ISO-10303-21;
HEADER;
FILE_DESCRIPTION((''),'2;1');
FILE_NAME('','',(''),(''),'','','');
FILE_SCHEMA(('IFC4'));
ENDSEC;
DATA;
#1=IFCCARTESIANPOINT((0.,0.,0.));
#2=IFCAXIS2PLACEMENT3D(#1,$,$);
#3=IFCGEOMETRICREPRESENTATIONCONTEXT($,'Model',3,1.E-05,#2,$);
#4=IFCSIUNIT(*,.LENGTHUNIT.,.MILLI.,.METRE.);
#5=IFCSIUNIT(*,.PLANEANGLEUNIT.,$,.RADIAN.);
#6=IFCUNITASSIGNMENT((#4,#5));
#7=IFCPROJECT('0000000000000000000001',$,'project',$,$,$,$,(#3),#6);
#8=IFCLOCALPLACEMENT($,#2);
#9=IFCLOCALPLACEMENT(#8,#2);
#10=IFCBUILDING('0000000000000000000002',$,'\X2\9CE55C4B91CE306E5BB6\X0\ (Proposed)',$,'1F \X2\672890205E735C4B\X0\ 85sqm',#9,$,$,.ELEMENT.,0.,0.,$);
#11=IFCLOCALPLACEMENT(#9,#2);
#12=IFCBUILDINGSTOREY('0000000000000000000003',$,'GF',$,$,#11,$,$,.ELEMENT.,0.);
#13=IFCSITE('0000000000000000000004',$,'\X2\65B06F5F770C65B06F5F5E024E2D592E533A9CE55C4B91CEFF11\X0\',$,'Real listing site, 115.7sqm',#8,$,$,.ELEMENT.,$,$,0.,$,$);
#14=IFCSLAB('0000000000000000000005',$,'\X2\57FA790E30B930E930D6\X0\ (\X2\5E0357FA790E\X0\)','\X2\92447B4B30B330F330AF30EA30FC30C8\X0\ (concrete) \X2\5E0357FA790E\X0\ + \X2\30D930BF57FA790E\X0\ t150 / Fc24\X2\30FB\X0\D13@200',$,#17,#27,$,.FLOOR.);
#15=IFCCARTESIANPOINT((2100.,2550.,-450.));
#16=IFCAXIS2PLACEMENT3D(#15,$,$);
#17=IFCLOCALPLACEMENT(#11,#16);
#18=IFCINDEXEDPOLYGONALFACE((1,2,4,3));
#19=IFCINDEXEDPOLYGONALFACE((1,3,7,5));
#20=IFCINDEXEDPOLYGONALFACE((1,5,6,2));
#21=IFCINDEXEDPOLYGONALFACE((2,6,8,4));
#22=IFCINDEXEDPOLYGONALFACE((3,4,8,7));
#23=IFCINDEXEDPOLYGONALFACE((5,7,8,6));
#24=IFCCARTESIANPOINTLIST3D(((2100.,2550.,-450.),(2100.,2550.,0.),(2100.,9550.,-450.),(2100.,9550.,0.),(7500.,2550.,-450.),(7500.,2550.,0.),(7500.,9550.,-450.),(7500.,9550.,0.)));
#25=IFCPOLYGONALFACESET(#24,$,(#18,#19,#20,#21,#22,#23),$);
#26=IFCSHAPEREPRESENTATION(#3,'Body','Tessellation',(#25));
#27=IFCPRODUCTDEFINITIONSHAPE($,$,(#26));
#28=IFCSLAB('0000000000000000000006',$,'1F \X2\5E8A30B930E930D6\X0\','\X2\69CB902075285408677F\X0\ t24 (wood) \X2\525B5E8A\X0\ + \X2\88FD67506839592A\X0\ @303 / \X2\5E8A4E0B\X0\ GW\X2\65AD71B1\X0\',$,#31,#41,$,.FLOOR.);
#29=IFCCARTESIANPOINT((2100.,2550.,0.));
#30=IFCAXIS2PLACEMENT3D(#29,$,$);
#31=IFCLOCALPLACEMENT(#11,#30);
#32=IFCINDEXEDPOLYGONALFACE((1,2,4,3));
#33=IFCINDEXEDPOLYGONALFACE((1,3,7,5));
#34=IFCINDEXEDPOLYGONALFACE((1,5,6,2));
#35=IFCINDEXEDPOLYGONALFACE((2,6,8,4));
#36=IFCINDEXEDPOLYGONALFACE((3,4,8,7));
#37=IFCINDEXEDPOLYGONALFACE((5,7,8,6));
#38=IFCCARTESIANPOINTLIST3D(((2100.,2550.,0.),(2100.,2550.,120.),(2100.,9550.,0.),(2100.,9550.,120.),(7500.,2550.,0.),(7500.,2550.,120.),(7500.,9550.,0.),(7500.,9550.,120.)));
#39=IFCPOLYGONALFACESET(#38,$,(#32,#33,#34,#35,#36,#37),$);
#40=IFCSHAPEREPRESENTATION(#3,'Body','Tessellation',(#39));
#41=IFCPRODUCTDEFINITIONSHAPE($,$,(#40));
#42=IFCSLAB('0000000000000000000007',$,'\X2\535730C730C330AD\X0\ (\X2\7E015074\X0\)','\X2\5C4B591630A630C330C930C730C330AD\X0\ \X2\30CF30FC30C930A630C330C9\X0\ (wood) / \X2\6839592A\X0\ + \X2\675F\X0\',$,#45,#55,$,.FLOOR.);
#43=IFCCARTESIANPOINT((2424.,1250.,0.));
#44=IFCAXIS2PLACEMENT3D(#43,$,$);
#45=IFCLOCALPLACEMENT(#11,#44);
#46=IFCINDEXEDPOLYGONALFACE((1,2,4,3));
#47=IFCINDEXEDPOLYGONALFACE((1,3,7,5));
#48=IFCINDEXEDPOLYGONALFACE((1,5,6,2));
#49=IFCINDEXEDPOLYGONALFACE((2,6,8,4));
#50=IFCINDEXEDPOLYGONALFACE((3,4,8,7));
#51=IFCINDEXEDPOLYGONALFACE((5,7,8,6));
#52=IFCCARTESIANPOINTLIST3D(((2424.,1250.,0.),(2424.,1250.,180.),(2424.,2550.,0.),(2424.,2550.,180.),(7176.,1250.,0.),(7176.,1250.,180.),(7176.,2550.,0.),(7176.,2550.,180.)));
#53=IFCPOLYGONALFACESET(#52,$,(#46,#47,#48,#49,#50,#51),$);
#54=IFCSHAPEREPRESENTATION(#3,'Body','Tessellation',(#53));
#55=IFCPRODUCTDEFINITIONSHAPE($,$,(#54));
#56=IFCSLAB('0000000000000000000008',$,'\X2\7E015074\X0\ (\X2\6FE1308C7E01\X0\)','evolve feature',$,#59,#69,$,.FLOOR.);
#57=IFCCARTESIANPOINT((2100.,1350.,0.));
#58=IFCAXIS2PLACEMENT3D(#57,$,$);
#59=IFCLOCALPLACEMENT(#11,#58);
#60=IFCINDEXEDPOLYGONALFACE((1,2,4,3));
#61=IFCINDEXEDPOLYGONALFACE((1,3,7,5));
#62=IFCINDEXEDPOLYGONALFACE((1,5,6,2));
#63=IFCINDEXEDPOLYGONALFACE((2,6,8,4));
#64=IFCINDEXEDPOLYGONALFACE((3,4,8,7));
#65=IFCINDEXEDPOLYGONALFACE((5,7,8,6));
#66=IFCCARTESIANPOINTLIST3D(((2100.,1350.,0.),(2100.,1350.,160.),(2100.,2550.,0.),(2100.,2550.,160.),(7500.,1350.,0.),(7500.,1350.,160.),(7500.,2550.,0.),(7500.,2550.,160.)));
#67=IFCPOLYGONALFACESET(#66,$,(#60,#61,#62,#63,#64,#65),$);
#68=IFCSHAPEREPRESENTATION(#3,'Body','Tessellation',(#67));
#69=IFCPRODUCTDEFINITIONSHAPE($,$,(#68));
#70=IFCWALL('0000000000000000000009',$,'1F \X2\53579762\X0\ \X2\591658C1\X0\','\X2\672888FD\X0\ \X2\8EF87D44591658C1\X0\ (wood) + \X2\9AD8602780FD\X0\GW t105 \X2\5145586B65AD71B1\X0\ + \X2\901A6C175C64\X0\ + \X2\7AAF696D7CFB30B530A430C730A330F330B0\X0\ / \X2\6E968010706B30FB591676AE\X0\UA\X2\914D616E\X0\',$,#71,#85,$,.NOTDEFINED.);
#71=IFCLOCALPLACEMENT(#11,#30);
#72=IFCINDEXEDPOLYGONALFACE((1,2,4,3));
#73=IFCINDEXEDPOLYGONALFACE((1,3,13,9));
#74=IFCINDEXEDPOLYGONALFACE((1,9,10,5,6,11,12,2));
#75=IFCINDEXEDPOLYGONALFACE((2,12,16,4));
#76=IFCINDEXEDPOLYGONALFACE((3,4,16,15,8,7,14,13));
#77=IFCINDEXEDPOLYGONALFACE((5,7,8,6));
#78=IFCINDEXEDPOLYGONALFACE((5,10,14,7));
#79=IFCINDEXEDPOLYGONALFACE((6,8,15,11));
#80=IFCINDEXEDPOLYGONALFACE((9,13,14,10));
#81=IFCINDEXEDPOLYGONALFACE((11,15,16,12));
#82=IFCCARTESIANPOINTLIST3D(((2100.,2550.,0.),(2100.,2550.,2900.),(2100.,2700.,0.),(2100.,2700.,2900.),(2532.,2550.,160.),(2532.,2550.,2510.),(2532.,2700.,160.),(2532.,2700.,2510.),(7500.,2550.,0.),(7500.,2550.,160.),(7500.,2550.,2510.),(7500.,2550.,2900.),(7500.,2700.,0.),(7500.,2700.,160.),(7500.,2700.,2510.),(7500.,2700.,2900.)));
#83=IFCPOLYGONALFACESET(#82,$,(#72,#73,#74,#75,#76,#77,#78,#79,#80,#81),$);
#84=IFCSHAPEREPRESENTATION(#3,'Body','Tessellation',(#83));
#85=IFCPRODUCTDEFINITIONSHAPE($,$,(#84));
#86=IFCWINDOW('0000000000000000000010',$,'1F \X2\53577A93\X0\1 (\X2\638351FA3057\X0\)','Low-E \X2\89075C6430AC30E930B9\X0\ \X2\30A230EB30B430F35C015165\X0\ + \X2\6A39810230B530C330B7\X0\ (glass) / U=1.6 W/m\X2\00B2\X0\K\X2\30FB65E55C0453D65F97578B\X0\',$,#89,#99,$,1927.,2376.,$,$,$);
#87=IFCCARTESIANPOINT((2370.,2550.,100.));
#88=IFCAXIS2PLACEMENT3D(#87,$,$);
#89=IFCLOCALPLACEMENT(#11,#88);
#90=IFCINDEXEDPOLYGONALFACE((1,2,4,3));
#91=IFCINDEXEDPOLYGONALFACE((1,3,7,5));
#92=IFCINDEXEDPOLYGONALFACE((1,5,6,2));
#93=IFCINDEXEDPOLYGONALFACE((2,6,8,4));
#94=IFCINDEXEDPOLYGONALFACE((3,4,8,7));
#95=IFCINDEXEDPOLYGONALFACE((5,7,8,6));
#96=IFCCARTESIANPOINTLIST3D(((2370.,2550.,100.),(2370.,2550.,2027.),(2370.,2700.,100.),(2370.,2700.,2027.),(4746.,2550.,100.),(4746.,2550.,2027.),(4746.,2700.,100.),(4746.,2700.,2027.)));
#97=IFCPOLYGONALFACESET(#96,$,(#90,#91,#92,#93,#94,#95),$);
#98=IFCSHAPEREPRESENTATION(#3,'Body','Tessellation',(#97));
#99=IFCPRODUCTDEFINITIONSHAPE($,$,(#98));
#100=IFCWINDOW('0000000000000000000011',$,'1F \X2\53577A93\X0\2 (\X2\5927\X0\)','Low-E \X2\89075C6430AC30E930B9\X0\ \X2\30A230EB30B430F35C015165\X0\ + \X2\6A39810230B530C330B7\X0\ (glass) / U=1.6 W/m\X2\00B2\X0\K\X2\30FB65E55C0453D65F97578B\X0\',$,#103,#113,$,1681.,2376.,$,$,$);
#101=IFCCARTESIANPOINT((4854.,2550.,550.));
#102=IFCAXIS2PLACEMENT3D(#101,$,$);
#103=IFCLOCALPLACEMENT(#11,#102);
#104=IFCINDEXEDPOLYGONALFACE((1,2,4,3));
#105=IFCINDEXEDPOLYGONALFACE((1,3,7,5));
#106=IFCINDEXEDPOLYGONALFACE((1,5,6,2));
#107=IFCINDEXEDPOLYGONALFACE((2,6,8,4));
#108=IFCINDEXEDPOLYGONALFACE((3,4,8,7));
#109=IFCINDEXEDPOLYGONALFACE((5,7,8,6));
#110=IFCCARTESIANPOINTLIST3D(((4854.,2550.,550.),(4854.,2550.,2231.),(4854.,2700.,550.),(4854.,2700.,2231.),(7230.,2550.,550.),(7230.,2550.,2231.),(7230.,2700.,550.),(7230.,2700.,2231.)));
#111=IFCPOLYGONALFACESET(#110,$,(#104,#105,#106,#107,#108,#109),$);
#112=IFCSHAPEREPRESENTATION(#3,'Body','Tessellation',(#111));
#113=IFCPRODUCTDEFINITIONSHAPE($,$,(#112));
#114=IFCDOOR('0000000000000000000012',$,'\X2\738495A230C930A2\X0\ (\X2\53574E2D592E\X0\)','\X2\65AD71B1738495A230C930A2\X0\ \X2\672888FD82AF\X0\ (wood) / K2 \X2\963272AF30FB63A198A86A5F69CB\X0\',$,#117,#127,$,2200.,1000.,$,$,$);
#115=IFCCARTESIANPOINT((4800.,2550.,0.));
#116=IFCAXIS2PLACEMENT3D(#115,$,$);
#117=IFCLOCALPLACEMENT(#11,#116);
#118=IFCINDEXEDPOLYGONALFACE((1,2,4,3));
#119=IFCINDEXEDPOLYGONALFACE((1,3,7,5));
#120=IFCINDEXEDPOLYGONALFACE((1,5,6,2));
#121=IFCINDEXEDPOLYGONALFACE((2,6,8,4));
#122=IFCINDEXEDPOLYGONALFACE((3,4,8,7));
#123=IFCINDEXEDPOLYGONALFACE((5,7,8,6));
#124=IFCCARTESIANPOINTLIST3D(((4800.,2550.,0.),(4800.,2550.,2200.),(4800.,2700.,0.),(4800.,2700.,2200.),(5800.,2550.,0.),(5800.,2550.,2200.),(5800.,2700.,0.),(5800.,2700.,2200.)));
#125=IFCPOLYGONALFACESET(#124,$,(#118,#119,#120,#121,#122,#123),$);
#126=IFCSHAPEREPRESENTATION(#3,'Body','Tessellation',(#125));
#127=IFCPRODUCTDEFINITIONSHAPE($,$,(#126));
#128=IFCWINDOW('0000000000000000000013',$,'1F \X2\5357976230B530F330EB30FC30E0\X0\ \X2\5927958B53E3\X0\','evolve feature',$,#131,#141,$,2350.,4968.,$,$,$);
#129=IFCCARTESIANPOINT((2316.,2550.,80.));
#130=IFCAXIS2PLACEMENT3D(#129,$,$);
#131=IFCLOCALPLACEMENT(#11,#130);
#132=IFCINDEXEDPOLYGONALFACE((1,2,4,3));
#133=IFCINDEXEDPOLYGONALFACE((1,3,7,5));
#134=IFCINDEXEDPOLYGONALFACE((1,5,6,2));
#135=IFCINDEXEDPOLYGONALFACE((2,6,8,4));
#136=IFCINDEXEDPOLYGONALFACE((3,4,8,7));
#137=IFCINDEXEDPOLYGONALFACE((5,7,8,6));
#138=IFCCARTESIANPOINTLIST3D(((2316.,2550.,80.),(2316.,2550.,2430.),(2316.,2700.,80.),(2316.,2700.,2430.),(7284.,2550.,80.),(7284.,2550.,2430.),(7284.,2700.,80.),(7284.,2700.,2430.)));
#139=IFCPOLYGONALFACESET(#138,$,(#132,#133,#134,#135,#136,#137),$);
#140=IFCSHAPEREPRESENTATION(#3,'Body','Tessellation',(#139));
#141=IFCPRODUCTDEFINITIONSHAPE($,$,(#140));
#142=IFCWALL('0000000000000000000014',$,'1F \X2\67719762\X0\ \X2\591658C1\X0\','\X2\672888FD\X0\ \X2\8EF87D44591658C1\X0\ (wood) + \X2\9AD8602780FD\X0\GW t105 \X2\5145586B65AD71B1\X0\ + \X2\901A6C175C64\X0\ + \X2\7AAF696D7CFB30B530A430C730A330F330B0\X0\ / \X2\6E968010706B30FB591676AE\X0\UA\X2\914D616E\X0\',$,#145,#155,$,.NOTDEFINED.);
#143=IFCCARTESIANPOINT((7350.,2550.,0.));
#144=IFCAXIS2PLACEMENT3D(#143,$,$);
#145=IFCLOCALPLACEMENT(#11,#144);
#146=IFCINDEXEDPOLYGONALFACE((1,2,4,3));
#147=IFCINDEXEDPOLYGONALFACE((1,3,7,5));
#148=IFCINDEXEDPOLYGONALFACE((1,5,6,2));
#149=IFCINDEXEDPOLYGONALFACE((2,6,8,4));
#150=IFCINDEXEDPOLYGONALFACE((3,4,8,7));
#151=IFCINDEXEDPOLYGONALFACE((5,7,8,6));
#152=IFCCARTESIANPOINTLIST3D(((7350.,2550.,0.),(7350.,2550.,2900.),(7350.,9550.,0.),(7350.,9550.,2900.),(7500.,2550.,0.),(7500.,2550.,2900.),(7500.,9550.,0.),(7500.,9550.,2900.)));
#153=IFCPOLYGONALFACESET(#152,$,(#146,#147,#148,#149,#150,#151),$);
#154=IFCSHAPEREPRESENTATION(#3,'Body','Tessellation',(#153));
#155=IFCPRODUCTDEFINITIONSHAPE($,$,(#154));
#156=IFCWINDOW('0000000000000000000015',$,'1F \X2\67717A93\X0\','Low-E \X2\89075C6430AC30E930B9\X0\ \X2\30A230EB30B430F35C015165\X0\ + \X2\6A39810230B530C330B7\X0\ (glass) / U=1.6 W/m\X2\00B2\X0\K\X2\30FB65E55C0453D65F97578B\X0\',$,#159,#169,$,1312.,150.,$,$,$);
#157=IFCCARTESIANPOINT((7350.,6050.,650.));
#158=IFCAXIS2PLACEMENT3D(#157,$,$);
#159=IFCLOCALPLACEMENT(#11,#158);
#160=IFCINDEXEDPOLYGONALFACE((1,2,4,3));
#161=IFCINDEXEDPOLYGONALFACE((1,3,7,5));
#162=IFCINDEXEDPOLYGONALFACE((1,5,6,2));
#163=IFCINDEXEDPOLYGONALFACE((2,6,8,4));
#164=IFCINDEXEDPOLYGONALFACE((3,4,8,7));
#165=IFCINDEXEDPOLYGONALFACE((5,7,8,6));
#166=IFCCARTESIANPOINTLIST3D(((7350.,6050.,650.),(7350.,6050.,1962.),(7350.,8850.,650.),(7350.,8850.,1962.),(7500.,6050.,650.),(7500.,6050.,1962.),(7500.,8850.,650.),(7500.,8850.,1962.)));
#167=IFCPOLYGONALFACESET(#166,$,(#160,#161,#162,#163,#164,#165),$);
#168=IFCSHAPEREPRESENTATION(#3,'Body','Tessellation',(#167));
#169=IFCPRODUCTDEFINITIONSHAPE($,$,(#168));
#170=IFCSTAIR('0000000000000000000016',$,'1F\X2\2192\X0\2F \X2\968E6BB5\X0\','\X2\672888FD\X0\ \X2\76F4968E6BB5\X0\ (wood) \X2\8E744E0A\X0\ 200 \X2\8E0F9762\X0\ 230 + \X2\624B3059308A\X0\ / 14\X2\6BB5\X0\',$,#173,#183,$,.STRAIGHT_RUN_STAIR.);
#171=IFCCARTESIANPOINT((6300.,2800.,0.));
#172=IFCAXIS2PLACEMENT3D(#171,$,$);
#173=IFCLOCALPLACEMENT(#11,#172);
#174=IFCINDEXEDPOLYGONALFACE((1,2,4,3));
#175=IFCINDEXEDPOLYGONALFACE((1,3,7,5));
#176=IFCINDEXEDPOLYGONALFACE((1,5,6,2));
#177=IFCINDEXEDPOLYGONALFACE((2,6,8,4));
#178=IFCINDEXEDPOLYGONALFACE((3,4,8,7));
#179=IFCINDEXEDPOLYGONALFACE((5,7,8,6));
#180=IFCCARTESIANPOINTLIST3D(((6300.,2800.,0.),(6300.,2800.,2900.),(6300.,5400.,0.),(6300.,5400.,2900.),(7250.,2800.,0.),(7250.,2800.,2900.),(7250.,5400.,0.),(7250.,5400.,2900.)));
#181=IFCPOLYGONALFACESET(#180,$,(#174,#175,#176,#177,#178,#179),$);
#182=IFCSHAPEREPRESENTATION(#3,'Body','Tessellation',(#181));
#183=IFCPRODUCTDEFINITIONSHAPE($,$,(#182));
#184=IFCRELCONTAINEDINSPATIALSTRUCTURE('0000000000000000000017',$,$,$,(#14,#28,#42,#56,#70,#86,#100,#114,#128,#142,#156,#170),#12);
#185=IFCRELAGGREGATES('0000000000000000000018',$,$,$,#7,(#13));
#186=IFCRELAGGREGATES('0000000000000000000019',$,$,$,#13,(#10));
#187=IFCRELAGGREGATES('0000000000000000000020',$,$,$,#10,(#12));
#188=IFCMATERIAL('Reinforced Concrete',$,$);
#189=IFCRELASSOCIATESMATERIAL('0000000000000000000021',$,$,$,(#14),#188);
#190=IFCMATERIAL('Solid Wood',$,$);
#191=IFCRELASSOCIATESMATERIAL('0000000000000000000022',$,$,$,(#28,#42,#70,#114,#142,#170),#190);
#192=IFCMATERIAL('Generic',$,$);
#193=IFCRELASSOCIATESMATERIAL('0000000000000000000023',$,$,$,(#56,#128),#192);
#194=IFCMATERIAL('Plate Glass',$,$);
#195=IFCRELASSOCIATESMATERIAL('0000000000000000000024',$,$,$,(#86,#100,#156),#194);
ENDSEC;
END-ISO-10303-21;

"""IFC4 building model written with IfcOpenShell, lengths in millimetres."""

from ifc_helpers import new_model, si_unit, frame, frame_2d, origin, place, context, project, spatial, rectangle, extrude, material, element, fill, save


model = new_model("IFC4")

# Units and contexts
model_context = context("Model", 3, precision=1e-05, world=origin())
ifc_project = project(units=[si_unit("LENGTHUNIT", "METRE", prefix="MILLI"), si_unit("PLANEANGLEUNIT", "RADIAN")], contexts=[model_context])

# Site, building, storey
site_placement = place(None, origin())
site = spatial("IfcSite", under=ifc_project, at=site_placement, Name="新潟県新潟市中央区鳥屋野１", ObjectType="Real listing site, 115.7sqm", CompositionType="ELEMENT", RefElevation=0.0)
building_placement = place(site_placement, origin())
building = spatial("IfcBuilding", under=site, at=building_placement, Name="鳥屋野の家 (Proposed)", ObjectType="1F 木造平屋 85sqm", CompositionType="ELEMENT", ElevationOfRefHeight=0.0, ElevationOfTerrain=0.0)
storey_placement = place(building_placement, origin())
storey = spatial("IfcBuildingStorey", under=building, at=storey_placement, Name="GF", CompositionType="ELEMENT", Elevation=0.0)

# Slabs
ifc_material_1 = material(Name="Reinforced Concrete")
slab_1_placement = place(storey_placement, frame((2100.0, 2550.0, -450.0)))
element("IfcSlab", 1, at=slab_1_placement, inside=storey, material=ifc_material_1, Name="基礎スラブ (布基礎)", Description="鉄筋コンクリート (concrete) 布基礎 + ベタ基礎 t150 / Fc24・D13@200", PredefinedType="FLOOR", context=model_context, shape_type="SweptSolid", body=[
    extrude(rectangle(XDim=5400.0, YDim=7000.0, at=frame_2d((2700.0, 3500.0))), frame((2100.0, 2550.0, -450.0)), (0.0, 0.0, 1.0), 450.0),
])
ifc_material_2 = material(Name="Solid Wood")
slab_2_placement = place(storey_placement, frame((2100.0, 2550.0, 0.0)))
element("IfcSlab", 2, at=slab_2_placement, inside=storey, material=ifc_material_2, Name="1F 床スラブ", Description="構造用合板 t24 (wood) 剛床 + 製材根太 @303 / 床下 GW断熱", PredefinedType="FLOOR", context=model_context, shape_type="SweptSolid", body=[
    extrude(rectangle(XDim=5400.0, YDim=7000.0, at=frame_2d((2700.0, 3500.0))), frame((2100.0, 2550.0, 0.0)), (0.0, 0.0, 1.0), 120.0),
])
slab_3_placement = place(storey_placement, frame((2424.0, 1250.0, 0.0)))
element("IfcSlab", 3, at=slab_3_placement, inside=storey, material=ifc_material_2, Name="南デッキ (縁側)", Description="屋外ウッドデッキ ハードウッド (wood) / 根太 + 束", PredefinedType="FLOOR", context=model_context, shape_type="SweptSolid", body=[
    extrude(rectangle(XDim=4752.0, YDim=1300.0, at=frame_2d((2376.0, 650.0))), frame((2424.0, 1250.0, 0.0)), (0.0, 0.0, 1.0), 180.0),
])
ifc_material_3 = material(Name="Generic")
slab_4_placement = place(storey_placement, frame((2100.0, 1350.0, 0.0)))
element("IfcSlab", 4, at=slab_4_placement, inside=storey, material=ifc_material_3, Name="縁側 (濡れ縁)", Description="evolve feature", PredefinedType="FLOOR", context=model_context, shape_type="SweptSolid", body=[
    extrude(rectangle(XDim=5400.0, YDim=1200.0, at=frame_2d((2700.0, 600.0))), frame((2100.0, 1350.0, 0.0)), (0.0, 0.0, 1.0), 160.0),
])

# Wall, openings, windows, door
wall_1_placement = place(storey_placement, frame((2100.0, 2550.0, 0.0)))
wall_1 = element("IfcWall", 5, at=wall_1_placement, inside=storey, material=ifc_material_2, Name="1F 南面 外壁", Description="木製 軸組外壁 (wood) + 高性能GW t105 充填断熱 + 通気層 + 窯業系サイディング / 準耐火・外皮UA配慮", PredefinedType="NOTDEFINED", context=model_context, shape_type="SweptSolid", body=[
    extrude(rectangle(XDim=5400.0, YDim=150.0, at=frame_2d((2700.0, 75.0))), frame((2100.0, 2550.0, 0.0)), (0.0, 0.0, 1.0), 2900.0),
])
opening_1_placement = place(storey_placement, frame((2370.0, 2550.0, 100.0)))
opening_1 = element("IfcOpeningElement", 6, at=opening_1_placement, cuts=wall_1, PredefinedType="NOTDEFINED", context=model_context, shape_type="SweptSolid", body=[
    extrude(rectangle(XDim=2376.0, YDim=150.0, at=frame_2d((1188.0, 75.0))), frame((2370.0, 2550.0, 100.0)), (0.0, 0.0, 1.0), 1927.0),
])
opening_2_placement = place(storey_placement, frame((4854.0, 2550.0, 550.0)))
opening_2 = element("IfcOpeningElement", 7, at=opening_2_placement, cuts=wall_1, PredefinedType="NOTDEFINED", context=model_context, shape_type="SweptSolid", body=[
    extrude(rectangle(XDim=2376.0, YDim=150.0, at=frame_2d((1188.0, 75.0))), frame((4854.0, 2550.0, 550.0)), (0.0, 0.0, 1.0), 1681.0),
])
opening_3_placement = place(storey_placement, frame((4800.0, 2550.0, 0.0)))
opening_3 = element("IfcOpeningElement", 8, at=opening_3_placement, cuts=wall_1, PredefinedType="NOTDEFINED", context=model_context, shape_type="SweptSolid", body=[
    extrude(rectangle(XDim=1000.0, YDim=150.0, at=frame_2d((500.0, 75.0))), frame((4800.0, 2550.0, 0.0)), (0.0, 0.0, 1.0), 2200.0),
])
opening_4_placement = place(storey_placement, frame((2316.0, 2550.0, 80.0)))
opening_4 = element("IfcOpeningElement", 9, at=opening_4_placement, cuts=wall_1, PredefinedType="NOTDEFINED", context=model_context, shape_type="SweptSolid", body=[
    extrude(rectangle(XDim=4968.0, YDim=150.0, at=frame_2d((2484.0, 75.0))), frame((2316.0, 2550.0, 80.0)), (0.0, 0.0, 1.0), 2350.0),
])
ifc_material_4 = material(Name="Plate Glass")
window_1_placement = place(storey_placement, frame((2370.0, 2550.0, 100.0)))
window_1 = element("IfcWindow", 10, at=window_1_placement, inside=storey, material=ifc_material_4, Name="1F 南窓1 (掃出し)", Description="Low-E 複層ガラス アルゴン封入 + 樹脂サッシ (glass) / U=1.6 W/m²K・日射取得型", OverallHeight=1927.0, OverallWidth=2376.0, context=model_context, shape_type="SweptSolid", body=[
    extrude(rectangle(XDim=2376.0, YDim=150.0, at=frame_2d((1188.0, 75.0))), frame((2370.0, 2550.0, 100.0)), (0.0, 0.0, 1.0), 1927.0),
])
fill(opening_1, window_1)
window_2_placement = place(storey_placement, frame((4854.0, 2550.0, 550.0)))
window_2 = element("IfcWindow", 11, at=window_2_placement, inside=storey, material=ifc_material_4, Name="1F 南窓2 (大)", Description="Low-E 複層ガラス アルゴン封入 + 樹脂サッシ (glass) / U=1.6 W/m²K・日射取得型", OverallHeight=1681.0, OverallWidth=2376.0, context=model_context, shape_type="SweptSolid", body=[
    extrude(rectangle(XDim=2376.0, YDim=150.0, at=frame_2d((1188.0, 75.0))), frame((4854.0, 2550.0, 550.0)), (0.0, 0.0, 1.0), 1681.0),
])
fill(opening_2, window_2)
door_placement = place(storey_placement, frame((4800.0, 2550.0, 0.0)))
door = element("IfcDoor", 12, at=door_placement, inside=storey, material=ifc_material_2, Name="玄関ドア (南中央)", Description="断熱玄関ドア 木製芯 (wood) / K2 防犯・採風機構", OverallHeight=2200.0, OverallWidth=1000.0, context=model_context, shape_type="SweptSolid", body=[
    extrude(rectangle(XDim=1000.0, YDim=150.0, at=frame_2d((500.0, 75.0))), frame((4800.0, 2550.0, 0.0)), (0.0, 0.0, 1.0), 2200.0),
])
fill(opening_3, door)
window_3_placement = place(storey_placement, frame((2316.0, 2550.0, 80.0)))
window_3 = element("IfcWindow", 13, at=window_3_placement, inside=storey, material=ifc_material_3, Name="1F 南面サンルーム 大開口", Description="evolve feature", OverallHeight=2350.0, OverallWidth=4968.0, context=model_context, shape_type="SweptSolid", body=[
    extrude(rectangle(XDim=4968.0, YDim=150.0, at=frame_2d((2484.0, 75.0))), frame((2316.0, 2550.0, 80.0)), (0.0, 0.0, 1.0), 2350.0),
])
fill(opening_4, window_3)

# Wall, opening, window
wall_2_placement = place(storey_placement, frame((7350.0, 2550.0, 0.0)))
wall_2 = element("IfcWall", 14, at=wall_2_placement, inside=storey, material=ifc_material_2, Name="1F 東面 外壁", Description="木製 軸組外壁 (wood) + 高性能GW t105 充填断熱 + 通気層 + 窯業系サイディング / 準耐火・外皮UA配慮", PredefinedType="NOTDEFINED", context=model_context, shape_type="SweptSolid", body=[
    extrude(rectangle(XDim=150.0, YDim=7000.0, at=frame_2d((75.0, 3500.0))), frame((7350.0, 2550.0, 0.0)), (0.0, 0.0, 1.0), 2900.0),
])
opening_5_placement = place(storey_placement, frame((7350.0, 6050.0, 650.0)))
opening_5 = element("IfcOpeningElement", 15, at=opening_5_placement, cuts=wall_2, PredefinedType="NOTDEFINED", context=model_context, shape_type="SweptSolid", body=[
    extrude(rectangle(XDim=150.0, YDim=2800.0, at=frame_2d((75.0, 1400.0))), frame((7350.0, 6050.0, 650.0)), (0.0, 0.0, 1.0), 1312.0),
])
window_4_placement = place(storey_placement, frame((7350.0, 6050.0, 650.0)))
window_4 = element("IfcWindow", 16, at=window_4_placement, inside=storey, material=ifc_material_4, Name="1F 東窓", Description="Low-E 複層ガラス アルゴン封入 + 樹脂サッシ (glass) / U=1.6 W/m²K・日射取得型", OverallHeight=1312.0, OverallWidth=150.0, context=model_context, shape_type="SweptSolid", body=[
    extrude(rectangle(XDim=150.0, YDim=2800.0, at=frame_2d((75.0, 1400.0))), frame((7350.0, 6050.0, 650.0)), (0.0, 0.0, 1.0), 1312.0),
])
fill(opening_5, window_4)

# Stair
stair_placement = place(storey_placement, frame((6300.0, 2800.0, 0.0)))
element("IfcStair", 17, at=stair_placement, inside=storey, material=ifc_material_2, Name="1F→2F 階段", Description="木製 直階段 (wood) 蹴上 200 踏面 230 + 手すり / 14段", PredefinedType="STRAIGHT_RUN_STAIR", context=model_context, shape_type="SweptSolid", body=[
    extrude(rectangle(XDim=950.0, YDim=2600.0, at=frame_2d((475.0, 1300.0))), frame((6300.0, 2800.0, 0.0)), (0.0, 0.0, 1.0), 2900.0),
])

save(model, "model.ifc")
